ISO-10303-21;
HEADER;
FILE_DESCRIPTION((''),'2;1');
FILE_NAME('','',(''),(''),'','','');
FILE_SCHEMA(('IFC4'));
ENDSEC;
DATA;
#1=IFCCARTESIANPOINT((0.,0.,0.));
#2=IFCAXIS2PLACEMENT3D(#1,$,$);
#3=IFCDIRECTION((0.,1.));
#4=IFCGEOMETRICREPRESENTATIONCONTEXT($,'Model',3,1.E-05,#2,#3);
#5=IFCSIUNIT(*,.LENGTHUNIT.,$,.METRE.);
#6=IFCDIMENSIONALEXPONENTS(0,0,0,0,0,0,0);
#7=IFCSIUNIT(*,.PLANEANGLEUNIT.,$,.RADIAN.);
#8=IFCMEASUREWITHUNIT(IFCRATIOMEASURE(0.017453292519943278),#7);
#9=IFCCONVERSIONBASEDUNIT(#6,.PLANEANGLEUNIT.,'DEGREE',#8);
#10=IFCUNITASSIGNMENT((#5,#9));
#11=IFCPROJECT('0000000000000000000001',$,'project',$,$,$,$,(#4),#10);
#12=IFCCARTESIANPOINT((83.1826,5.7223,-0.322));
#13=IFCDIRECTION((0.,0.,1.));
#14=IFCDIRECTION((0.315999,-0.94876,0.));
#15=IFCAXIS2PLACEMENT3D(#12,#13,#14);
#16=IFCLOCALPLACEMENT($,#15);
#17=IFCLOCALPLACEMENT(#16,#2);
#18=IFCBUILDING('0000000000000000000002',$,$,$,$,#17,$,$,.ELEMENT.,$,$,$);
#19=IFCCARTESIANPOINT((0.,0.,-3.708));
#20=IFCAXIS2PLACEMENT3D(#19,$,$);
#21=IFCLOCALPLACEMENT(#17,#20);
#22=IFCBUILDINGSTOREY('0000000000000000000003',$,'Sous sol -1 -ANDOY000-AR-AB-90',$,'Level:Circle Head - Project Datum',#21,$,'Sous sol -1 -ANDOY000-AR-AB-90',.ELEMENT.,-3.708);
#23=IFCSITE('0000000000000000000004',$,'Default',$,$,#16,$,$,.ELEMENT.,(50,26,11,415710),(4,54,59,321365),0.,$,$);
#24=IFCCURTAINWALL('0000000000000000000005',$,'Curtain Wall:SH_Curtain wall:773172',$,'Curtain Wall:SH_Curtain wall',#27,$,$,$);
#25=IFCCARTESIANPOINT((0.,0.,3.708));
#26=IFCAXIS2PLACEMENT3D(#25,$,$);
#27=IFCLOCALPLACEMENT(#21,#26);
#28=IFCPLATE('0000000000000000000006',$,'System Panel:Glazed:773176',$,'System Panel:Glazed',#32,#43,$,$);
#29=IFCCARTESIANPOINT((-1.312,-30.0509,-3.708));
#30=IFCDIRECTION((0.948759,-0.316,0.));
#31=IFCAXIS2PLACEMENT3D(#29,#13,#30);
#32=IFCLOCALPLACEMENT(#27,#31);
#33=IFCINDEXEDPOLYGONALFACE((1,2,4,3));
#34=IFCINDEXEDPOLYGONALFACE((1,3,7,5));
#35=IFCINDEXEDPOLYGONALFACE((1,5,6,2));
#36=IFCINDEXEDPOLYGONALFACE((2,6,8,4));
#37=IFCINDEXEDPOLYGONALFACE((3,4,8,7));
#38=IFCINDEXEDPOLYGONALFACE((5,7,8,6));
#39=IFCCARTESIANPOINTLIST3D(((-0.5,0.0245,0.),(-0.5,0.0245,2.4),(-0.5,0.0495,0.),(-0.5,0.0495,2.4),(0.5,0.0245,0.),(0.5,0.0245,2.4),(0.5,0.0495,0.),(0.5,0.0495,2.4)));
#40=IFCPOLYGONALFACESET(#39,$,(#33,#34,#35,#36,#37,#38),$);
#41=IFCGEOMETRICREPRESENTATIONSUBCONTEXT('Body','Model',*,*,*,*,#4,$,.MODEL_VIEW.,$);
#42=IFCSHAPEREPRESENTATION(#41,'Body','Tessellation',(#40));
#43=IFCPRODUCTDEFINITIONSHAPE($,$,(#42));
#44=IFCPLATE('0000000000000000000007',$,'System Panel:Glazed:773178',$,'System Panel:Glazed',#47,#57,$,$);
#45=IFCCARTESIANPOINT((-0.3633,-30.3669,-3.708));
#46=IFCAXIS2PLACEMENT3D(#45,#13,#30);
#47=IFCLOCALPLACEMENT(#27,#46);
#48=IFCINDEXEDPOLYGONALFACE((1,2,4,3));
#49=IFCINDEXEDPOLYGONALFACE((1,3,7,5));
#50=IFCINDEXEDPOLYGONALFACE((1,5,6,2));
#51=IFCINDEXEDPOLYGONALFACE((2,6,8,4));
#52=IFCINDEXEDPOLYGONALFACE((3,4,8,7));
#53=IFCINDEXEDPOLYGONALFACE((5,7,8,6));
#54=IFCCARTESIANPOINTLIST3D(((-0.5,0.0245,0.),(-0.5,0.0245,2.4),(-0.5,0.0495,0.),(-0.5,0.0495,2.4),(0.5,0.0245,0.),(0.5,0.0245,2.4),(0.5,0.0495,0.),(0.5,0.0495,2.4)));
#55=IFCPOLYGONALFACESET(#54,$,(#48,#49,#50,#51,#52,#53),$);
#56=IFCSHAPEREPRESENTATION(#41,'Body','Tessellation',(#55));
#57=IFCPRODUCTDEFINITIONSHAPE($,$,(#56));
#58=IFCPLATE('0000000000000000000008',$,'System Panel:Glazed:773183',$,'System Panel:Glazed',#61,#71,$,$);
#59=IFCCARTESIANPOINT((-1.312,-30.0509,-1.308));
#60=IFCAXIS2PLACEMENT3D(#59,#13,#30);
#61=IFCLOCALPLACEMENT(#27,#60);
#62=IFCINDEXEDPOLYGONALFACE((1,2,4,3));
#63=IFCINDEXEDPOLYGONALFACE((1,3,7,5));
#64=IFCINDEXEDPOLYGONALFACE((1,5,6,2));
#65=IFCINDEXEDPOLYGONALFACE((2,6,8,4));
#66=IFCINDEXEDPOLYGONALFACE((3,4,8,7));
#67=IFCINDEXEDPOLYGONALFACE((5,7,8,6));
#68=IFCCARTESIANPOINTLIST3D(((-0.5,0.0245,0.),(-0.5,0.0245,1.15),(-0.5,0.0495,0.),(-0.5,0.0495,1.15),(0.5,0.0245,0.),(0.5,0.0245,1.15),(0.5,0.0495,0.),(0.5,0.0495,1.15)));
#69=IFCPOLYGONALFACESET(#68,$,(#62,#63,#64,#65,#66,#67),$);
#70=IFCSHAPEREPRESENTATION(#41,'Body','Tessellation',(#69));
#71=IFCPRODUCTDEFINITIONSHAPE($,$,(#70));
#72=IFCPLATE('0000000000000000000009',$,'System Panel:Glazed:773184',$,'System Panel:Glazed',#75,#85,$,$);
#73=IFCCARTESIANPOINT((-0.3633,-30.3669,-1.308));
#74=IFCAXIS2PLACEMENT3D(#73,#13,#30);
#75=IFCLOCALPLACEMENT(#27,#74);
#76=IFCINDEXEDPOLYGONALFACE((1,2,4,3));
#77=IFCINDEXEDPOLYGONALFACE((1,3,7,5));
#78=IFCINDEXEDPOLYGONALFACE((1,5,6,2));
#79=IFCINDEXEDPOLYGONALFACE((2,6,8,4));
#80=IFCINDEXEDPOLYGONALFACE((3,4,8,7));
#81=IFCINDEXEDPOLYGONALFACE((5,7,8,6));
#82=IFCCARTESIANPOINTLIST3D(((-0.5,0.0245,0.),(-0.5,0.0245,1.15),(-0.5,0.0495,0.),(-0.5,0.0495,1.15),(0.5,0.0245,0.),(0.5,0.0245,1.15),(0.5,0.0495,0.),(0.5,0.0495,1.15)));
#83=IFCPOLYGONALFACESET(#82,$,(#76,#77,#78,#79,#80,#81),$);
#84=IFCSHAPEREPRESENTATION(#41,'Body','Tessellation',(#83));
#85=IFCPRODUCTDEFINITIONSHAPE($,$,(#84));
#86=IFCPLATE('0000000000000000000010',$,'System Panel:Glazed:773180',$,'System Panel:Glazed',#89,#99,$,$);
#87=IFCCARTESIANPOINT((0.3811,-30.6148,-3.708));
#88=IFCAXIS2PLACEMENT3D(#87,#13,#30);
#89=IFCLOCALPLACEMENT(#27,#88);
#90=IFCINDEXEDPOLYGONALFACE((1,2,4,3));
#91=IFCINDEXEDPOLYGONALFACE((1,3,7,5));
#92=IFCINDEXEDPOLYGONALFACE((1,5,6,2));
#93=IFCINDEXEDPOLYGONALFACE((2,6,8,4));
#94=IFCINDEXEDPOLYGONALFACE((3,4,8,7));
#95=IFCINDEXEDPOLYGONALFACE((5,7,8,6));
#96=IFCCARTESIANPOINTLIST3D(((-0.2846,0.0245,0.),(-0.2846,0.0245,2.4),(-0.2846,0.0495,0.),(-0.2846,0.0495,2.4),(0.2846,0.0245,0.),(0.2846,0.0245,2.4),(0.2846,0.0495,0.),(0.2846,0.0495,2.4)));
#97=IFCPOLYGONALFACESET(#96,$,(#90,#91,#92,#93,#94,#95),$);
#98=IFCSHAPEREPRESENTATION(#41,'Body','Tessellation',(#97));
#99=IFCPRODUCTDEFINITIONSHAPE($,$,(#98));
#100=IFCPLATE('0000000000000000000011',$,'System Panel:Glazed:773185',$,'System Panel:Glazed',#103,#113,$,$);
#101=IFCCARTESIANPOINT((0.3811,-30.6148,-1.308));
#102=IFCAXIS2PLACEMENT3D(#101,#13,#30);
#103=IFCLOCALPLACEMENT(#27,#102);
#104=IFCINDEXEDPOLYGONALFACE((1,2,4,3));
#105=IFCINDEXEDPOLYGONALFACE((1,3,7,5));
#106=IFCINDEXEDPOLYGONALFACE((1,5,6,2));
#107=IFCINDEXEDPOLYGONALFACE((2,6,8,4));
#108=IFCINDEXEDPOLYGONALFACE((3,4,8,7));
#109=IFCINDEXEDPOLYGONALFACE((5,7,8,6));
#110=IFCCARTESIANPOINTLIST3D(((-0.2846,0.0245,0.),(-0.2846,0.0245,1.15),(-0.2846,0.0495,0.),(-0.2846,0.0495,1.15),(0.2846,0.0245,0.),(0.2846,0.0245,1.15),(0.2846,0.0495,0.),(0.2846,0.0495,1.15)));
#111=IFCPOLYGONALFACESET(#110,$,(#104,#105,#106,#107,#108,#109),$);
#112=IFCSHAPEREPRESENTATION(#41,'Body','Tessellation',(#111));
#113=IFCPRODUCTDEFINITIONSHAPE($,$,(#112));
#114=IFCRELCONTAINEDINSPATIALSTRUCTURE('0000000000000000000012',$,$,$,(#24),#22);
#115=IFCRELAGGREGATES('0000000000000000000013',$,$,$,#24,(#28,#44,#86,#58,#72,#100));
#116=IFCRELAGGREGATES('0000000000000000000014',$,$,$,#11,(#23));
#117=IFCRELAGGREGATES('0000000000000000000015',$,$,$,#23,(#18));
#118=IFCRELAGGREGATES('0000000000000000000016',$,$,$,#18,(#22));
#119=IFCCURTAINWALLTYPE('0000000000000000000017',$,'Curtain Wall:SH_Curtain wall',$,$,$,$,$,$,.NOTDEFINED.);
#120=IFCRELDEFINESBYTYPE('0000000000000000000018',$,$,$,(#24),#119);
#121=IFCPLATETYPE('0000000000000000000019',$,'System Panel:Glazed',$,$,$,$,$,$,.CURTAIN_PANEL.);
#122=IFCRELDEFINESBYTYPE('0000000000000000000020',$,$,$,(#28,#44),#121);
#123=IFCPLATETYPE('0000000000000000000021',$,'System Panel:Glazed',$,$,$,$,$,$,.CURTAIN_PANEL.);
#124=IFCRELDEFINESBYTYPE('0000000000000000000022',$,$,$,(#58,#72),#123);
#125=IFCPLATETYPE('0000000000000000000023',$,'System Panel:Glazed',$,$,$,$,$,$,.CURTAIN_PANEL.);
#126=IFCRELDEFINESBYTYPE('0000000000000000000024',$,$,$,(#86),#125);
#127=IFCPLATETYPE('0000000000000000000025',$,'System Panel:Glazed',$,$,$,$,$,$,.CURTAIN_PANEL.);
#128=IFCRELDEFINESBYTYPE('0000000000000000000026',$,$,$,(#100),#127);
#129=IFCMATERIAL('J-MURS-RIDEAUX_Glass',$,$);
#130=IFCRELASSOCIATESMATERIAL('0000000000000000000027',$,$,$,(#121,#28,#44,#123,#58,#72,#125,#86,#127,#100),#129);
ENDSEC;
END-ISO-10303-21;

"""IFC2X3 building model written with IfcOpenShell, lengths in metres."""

from ifc_helpers import new_model, entity, si_unit, converted_unit, direction, frame, frame_2d, origin, origin_2d_with_axis, place, context, subcontext, project, spatial, rectangle, extrude, source, transform, mapped, material, type_object, type_shapes, element, aggregate, save


model = new_model("IFC2X3")

# Units and contexts
model_context = context("Model", 3, precision=1e-05, world=origin(), true_north=direction((0.0, 1.0)))
body_context = subcontext(model_context, "Body", "Model", "MODEL_VIEW")
ifc_project = project(units=[si_unit("LENGTHUNIT", "METRE"), converted_unit("PLANEANGLEUNIT", "DEGREE", entity("IfcRatioMeasure", 0.017453292519943278), si_unit("PLANEANGLEUNIT", "RADIAN"), dimensions=[0, 0, 0, 0, 0, 0, 0])], contexts=[model_context])

# Site, building, storey
site_placement = place(None, frame((83.1826, 5.7223, -0.322), z_axis=(0.0, 0.0, 1.0), x_axis=(0.315999, -0.94876, 0.0)))
site = spatial("IfcSite", under=ifc_project, at=site_placement, Name="Default", CompositionType="ELEMENT", RefLatitude=(50, 26, 11, 415710), RefLongitude=(4, 54, 59, 321365), RefElevation=0.0)
building_placement = place(site_placement, origin())
building = spatial("IfcBuilding", under=site, at=building_placement, CompositionType="ELEMENT")
storey_placement = place(building_placement, frame((0.0, 0.0, -3.708)))
storey = spatial("IfcBuildingStorey", under=building, at=storey_placement, Name="Sous sol -1 -ANDOY000-AR-AB-90", ObjectType="Level:Circle Head - Project Datum", LongName="Sous sol -1 -ANDOY000-AR-AB-90", CompositionType="ELEMENT", Elevation=-3.708)

# Curtain wall, plates
curtain_wall_type = type_object("IfcCurtainWallType", Name="Curtain Wall:SH_Curtain wall", PredefinedType="NOTDEFINED")
curtain_wall_placement = place(storey_placement, frame((0.0, 0.0, 3.708)))
curtain_wall = element("IfcCurtainWall", 1, at=curtain_wall_placement, inside=storey, type_object=curtain_wall_type, Name="Curtain Wall:SH_Curtain wall:773172", ObjectType="Curtain Wall:SH_Curtain wall")
ifc_material_1 = material(Name="J-MURS-RIDEAUX_Glass")
plate_type_1 = type_object("IfcPlateType", Name="System Panel:Glazed", PredefinedType="CURTAIN_PANEL", material=ifc_material_1)
shared_shape_1 = source(origin(), body_context, "Body", "SweptSolid", [
    extrude(rectangle(XDim=0.025, YDim=1.0, at=frame_2d((0.0, 0.0), x_axis=(1.0, 0.0))), frame((0.0, 0.037, 0.0), z_axis=(0.0, 0.0, 1.0), x_axis=(0.0, 1.0, 0.0)), (0.0, 0.0, 1.0), 2.4),
])
type_shapes(plate_type_1, [shared_shape_1])
plate_1_placement = place(curtain_wall_placement, frame((-1.312, -30.0509, -3.708), z_axis=(0.0, 0.0, 1.0), x_axis=(0.948759, -0.316, 0.0)))
plate_1 = element("IfcPlate", 2, at=plate_1_placement, type_object=plate_type_1, material=ifc_material_1, Name="System Panel:Glazed:773176", ObjectType="System Panel:Glazed", context=body_context, shape_type="MappedRepresentation", body=[
    mapped(shared_shape_1, transform((0.0, 0.0, 0.0), scale=1.0)),
])
plate_2_placement = place(curtain_wall_placement, frame((-0.3633, -30.3669, -3.708), z_axis=(0.0, 0.0, 1.0), x_axis=(0.948759, -0.316, 0.0)))
plate_2 = element("IfcPlate", 3, at=plate_2_placement, type_object=plate_type_1, material=ifc_material_1, Name="System Panel:Glazed:773178", ObjectType="System Panel:Glazed", context=body_context, shape_type="MappedRepresentation", body=[
    mapped(shared_shape_1, transform((0.0, 0.0, 0.0), scale=1.0)),
])
plate_type_2 = type_object("IfcPlateType", Name="System Panel:Glazed", PredefinedType="CURTAIN_PANEL", material=ifc_material_1)
shared_shape_2 = source(origin(), body_context, "Body", "SweptSolid", [
    extrude(rectangle(XDim=0.025, YDim=1.0, at=origin_2d_with_axis()), frame((0.0, 0.037, 0.0), z_axis=(0.0, 0.0, 1.0), x_axis=(0.0, 1.0, 0.0)), (0.0, 0.0, 1.0), 1.15),
])
type_shapes(plate_type_2, [shared_shape_2])
plate_3_placement = place(curtain_wall_placement, frame((-1.312, -30.0509, -1.308), z_axis=(0.0, 0.0, 1.0), x_axis=(0.948759, -0.316, 0.0)))
plate_3 = element("IfcPlate", 4, at=plate_3_placement, type_object=plate_type_2, material=ifc_material_1, Name="System Panel:Glazed:773183", ObjectType="System Panel:Glazed", context=body_context, shape_type="MappedRepresentation", body=[
    mapped(shared_shape_2, transform((0.0, 0.0, 0.0), scale=1.0)),
])
plate_4_placement = place(curtain_wall_placement, frame((-0.3633, -30.3669, -1.308), z_axis=(0.0, 0.0, 1.0), x_axis=(0.948759, -0.316, 0.0)))
plate_4 = element("IfcPlate", 5, at=plate_4_placement, type_object=plate_type_2, material=ifc_material_1, Name="System Panel:Glazed:773184", ObjectType="System Panel:Glazed", context=body_context, shape_type="MappedRepresentation", body=[
    mapped(shared_shape_2, transform((0.0, 0.0, 0.0), scale=1.0)),
])
plate_type_3 = type_object("IfcPlateType", Name="System Panel:Glazed", PredefinedType="CURTAIN_PANEL", material=ifc_material_1)
shared_shape_3 = source(origin(), body_context, "Body", "SweptSolid", [
    extrude(rectangle(XDim=0.025, YDim=0.5692, at=frame_2d((0.0, 0.0), x_axis=(1.0, 0.0))), frame((0.0, 0.037, 0.0), z_axis=(0.0, 0.0, 1.0), x_axis=(0.0, 1.0, 0.0)), (0.0, 0.0, 1.0), 2.4),
])
type_shapes(plate_type_3, [shared_shape_3])
plate_5_placement = place(curtain_wall_placement, frame((0.3811, -30.6148, -3.708), z_axis=(0.0, 0.0, 1.0), x_axis=(0.948759, -0.316, 0.0)))
plate_5 = element("IfcPlate", 6, at=plate_5_placement, type_object=plate_type_3, material=ifc_material_1, Name="System Panel:Glazed:773180", ObjectType="System Panel:Glazed", context=body_context, shape_type="MappedRepresentation", body=[
    mapped(shared_shape_3, transform((0.0, 0.0, 0.0), scale=1.0)),
])
plate_type_4 = type_object("IfcPlateType", Name="System Panel:Glazed", PredefinedType="CURTAIN_PANEL", material=ifc_material_1)
shared_shape_4 = source(origin(), body_context, "Body", "SweptSolid", [
    extrude(rectangle(XDim=0.025, YDim=0.5692, at=frame_2d((0.0, 0.0), x_axis=(1.0, 0.0))), frame((0.0, 0.037, 0.0), z_axis=(0.0, 0.0, 1.0), x_axis=(0.0, 1.0, 0.0)), (0.0, 0.0, 1.0), 1.15),
])
type_shapes(plate_type_4, [shared_shape_4])
plate_6_placement = place(curtain_wall_placement, frame((0.3811, -30.6148, -1.308), z_axis=(0.0, 0.0, 1.0), x_axis=(0.948759, -0.316, 0.0)))
plate_6 = element("IfcPlate", 7, at=plate_6_placement, type_object=plate_type_4, material=ifc_material_1, Name="System Panel:Glazed:773185", ObjectType="System Panel:Glazed", context=body_context, shape_type="MappedRepresentation", body=[
    mapped(shared_shape_4, transform((0.0, 0.0, 0.0), scale=1.0)),
])
aggregate(curtain_wall, [plate_1, plate_2, plate_5, plate_3, plate_4, plate_6])

save(model, "model.ifc")
